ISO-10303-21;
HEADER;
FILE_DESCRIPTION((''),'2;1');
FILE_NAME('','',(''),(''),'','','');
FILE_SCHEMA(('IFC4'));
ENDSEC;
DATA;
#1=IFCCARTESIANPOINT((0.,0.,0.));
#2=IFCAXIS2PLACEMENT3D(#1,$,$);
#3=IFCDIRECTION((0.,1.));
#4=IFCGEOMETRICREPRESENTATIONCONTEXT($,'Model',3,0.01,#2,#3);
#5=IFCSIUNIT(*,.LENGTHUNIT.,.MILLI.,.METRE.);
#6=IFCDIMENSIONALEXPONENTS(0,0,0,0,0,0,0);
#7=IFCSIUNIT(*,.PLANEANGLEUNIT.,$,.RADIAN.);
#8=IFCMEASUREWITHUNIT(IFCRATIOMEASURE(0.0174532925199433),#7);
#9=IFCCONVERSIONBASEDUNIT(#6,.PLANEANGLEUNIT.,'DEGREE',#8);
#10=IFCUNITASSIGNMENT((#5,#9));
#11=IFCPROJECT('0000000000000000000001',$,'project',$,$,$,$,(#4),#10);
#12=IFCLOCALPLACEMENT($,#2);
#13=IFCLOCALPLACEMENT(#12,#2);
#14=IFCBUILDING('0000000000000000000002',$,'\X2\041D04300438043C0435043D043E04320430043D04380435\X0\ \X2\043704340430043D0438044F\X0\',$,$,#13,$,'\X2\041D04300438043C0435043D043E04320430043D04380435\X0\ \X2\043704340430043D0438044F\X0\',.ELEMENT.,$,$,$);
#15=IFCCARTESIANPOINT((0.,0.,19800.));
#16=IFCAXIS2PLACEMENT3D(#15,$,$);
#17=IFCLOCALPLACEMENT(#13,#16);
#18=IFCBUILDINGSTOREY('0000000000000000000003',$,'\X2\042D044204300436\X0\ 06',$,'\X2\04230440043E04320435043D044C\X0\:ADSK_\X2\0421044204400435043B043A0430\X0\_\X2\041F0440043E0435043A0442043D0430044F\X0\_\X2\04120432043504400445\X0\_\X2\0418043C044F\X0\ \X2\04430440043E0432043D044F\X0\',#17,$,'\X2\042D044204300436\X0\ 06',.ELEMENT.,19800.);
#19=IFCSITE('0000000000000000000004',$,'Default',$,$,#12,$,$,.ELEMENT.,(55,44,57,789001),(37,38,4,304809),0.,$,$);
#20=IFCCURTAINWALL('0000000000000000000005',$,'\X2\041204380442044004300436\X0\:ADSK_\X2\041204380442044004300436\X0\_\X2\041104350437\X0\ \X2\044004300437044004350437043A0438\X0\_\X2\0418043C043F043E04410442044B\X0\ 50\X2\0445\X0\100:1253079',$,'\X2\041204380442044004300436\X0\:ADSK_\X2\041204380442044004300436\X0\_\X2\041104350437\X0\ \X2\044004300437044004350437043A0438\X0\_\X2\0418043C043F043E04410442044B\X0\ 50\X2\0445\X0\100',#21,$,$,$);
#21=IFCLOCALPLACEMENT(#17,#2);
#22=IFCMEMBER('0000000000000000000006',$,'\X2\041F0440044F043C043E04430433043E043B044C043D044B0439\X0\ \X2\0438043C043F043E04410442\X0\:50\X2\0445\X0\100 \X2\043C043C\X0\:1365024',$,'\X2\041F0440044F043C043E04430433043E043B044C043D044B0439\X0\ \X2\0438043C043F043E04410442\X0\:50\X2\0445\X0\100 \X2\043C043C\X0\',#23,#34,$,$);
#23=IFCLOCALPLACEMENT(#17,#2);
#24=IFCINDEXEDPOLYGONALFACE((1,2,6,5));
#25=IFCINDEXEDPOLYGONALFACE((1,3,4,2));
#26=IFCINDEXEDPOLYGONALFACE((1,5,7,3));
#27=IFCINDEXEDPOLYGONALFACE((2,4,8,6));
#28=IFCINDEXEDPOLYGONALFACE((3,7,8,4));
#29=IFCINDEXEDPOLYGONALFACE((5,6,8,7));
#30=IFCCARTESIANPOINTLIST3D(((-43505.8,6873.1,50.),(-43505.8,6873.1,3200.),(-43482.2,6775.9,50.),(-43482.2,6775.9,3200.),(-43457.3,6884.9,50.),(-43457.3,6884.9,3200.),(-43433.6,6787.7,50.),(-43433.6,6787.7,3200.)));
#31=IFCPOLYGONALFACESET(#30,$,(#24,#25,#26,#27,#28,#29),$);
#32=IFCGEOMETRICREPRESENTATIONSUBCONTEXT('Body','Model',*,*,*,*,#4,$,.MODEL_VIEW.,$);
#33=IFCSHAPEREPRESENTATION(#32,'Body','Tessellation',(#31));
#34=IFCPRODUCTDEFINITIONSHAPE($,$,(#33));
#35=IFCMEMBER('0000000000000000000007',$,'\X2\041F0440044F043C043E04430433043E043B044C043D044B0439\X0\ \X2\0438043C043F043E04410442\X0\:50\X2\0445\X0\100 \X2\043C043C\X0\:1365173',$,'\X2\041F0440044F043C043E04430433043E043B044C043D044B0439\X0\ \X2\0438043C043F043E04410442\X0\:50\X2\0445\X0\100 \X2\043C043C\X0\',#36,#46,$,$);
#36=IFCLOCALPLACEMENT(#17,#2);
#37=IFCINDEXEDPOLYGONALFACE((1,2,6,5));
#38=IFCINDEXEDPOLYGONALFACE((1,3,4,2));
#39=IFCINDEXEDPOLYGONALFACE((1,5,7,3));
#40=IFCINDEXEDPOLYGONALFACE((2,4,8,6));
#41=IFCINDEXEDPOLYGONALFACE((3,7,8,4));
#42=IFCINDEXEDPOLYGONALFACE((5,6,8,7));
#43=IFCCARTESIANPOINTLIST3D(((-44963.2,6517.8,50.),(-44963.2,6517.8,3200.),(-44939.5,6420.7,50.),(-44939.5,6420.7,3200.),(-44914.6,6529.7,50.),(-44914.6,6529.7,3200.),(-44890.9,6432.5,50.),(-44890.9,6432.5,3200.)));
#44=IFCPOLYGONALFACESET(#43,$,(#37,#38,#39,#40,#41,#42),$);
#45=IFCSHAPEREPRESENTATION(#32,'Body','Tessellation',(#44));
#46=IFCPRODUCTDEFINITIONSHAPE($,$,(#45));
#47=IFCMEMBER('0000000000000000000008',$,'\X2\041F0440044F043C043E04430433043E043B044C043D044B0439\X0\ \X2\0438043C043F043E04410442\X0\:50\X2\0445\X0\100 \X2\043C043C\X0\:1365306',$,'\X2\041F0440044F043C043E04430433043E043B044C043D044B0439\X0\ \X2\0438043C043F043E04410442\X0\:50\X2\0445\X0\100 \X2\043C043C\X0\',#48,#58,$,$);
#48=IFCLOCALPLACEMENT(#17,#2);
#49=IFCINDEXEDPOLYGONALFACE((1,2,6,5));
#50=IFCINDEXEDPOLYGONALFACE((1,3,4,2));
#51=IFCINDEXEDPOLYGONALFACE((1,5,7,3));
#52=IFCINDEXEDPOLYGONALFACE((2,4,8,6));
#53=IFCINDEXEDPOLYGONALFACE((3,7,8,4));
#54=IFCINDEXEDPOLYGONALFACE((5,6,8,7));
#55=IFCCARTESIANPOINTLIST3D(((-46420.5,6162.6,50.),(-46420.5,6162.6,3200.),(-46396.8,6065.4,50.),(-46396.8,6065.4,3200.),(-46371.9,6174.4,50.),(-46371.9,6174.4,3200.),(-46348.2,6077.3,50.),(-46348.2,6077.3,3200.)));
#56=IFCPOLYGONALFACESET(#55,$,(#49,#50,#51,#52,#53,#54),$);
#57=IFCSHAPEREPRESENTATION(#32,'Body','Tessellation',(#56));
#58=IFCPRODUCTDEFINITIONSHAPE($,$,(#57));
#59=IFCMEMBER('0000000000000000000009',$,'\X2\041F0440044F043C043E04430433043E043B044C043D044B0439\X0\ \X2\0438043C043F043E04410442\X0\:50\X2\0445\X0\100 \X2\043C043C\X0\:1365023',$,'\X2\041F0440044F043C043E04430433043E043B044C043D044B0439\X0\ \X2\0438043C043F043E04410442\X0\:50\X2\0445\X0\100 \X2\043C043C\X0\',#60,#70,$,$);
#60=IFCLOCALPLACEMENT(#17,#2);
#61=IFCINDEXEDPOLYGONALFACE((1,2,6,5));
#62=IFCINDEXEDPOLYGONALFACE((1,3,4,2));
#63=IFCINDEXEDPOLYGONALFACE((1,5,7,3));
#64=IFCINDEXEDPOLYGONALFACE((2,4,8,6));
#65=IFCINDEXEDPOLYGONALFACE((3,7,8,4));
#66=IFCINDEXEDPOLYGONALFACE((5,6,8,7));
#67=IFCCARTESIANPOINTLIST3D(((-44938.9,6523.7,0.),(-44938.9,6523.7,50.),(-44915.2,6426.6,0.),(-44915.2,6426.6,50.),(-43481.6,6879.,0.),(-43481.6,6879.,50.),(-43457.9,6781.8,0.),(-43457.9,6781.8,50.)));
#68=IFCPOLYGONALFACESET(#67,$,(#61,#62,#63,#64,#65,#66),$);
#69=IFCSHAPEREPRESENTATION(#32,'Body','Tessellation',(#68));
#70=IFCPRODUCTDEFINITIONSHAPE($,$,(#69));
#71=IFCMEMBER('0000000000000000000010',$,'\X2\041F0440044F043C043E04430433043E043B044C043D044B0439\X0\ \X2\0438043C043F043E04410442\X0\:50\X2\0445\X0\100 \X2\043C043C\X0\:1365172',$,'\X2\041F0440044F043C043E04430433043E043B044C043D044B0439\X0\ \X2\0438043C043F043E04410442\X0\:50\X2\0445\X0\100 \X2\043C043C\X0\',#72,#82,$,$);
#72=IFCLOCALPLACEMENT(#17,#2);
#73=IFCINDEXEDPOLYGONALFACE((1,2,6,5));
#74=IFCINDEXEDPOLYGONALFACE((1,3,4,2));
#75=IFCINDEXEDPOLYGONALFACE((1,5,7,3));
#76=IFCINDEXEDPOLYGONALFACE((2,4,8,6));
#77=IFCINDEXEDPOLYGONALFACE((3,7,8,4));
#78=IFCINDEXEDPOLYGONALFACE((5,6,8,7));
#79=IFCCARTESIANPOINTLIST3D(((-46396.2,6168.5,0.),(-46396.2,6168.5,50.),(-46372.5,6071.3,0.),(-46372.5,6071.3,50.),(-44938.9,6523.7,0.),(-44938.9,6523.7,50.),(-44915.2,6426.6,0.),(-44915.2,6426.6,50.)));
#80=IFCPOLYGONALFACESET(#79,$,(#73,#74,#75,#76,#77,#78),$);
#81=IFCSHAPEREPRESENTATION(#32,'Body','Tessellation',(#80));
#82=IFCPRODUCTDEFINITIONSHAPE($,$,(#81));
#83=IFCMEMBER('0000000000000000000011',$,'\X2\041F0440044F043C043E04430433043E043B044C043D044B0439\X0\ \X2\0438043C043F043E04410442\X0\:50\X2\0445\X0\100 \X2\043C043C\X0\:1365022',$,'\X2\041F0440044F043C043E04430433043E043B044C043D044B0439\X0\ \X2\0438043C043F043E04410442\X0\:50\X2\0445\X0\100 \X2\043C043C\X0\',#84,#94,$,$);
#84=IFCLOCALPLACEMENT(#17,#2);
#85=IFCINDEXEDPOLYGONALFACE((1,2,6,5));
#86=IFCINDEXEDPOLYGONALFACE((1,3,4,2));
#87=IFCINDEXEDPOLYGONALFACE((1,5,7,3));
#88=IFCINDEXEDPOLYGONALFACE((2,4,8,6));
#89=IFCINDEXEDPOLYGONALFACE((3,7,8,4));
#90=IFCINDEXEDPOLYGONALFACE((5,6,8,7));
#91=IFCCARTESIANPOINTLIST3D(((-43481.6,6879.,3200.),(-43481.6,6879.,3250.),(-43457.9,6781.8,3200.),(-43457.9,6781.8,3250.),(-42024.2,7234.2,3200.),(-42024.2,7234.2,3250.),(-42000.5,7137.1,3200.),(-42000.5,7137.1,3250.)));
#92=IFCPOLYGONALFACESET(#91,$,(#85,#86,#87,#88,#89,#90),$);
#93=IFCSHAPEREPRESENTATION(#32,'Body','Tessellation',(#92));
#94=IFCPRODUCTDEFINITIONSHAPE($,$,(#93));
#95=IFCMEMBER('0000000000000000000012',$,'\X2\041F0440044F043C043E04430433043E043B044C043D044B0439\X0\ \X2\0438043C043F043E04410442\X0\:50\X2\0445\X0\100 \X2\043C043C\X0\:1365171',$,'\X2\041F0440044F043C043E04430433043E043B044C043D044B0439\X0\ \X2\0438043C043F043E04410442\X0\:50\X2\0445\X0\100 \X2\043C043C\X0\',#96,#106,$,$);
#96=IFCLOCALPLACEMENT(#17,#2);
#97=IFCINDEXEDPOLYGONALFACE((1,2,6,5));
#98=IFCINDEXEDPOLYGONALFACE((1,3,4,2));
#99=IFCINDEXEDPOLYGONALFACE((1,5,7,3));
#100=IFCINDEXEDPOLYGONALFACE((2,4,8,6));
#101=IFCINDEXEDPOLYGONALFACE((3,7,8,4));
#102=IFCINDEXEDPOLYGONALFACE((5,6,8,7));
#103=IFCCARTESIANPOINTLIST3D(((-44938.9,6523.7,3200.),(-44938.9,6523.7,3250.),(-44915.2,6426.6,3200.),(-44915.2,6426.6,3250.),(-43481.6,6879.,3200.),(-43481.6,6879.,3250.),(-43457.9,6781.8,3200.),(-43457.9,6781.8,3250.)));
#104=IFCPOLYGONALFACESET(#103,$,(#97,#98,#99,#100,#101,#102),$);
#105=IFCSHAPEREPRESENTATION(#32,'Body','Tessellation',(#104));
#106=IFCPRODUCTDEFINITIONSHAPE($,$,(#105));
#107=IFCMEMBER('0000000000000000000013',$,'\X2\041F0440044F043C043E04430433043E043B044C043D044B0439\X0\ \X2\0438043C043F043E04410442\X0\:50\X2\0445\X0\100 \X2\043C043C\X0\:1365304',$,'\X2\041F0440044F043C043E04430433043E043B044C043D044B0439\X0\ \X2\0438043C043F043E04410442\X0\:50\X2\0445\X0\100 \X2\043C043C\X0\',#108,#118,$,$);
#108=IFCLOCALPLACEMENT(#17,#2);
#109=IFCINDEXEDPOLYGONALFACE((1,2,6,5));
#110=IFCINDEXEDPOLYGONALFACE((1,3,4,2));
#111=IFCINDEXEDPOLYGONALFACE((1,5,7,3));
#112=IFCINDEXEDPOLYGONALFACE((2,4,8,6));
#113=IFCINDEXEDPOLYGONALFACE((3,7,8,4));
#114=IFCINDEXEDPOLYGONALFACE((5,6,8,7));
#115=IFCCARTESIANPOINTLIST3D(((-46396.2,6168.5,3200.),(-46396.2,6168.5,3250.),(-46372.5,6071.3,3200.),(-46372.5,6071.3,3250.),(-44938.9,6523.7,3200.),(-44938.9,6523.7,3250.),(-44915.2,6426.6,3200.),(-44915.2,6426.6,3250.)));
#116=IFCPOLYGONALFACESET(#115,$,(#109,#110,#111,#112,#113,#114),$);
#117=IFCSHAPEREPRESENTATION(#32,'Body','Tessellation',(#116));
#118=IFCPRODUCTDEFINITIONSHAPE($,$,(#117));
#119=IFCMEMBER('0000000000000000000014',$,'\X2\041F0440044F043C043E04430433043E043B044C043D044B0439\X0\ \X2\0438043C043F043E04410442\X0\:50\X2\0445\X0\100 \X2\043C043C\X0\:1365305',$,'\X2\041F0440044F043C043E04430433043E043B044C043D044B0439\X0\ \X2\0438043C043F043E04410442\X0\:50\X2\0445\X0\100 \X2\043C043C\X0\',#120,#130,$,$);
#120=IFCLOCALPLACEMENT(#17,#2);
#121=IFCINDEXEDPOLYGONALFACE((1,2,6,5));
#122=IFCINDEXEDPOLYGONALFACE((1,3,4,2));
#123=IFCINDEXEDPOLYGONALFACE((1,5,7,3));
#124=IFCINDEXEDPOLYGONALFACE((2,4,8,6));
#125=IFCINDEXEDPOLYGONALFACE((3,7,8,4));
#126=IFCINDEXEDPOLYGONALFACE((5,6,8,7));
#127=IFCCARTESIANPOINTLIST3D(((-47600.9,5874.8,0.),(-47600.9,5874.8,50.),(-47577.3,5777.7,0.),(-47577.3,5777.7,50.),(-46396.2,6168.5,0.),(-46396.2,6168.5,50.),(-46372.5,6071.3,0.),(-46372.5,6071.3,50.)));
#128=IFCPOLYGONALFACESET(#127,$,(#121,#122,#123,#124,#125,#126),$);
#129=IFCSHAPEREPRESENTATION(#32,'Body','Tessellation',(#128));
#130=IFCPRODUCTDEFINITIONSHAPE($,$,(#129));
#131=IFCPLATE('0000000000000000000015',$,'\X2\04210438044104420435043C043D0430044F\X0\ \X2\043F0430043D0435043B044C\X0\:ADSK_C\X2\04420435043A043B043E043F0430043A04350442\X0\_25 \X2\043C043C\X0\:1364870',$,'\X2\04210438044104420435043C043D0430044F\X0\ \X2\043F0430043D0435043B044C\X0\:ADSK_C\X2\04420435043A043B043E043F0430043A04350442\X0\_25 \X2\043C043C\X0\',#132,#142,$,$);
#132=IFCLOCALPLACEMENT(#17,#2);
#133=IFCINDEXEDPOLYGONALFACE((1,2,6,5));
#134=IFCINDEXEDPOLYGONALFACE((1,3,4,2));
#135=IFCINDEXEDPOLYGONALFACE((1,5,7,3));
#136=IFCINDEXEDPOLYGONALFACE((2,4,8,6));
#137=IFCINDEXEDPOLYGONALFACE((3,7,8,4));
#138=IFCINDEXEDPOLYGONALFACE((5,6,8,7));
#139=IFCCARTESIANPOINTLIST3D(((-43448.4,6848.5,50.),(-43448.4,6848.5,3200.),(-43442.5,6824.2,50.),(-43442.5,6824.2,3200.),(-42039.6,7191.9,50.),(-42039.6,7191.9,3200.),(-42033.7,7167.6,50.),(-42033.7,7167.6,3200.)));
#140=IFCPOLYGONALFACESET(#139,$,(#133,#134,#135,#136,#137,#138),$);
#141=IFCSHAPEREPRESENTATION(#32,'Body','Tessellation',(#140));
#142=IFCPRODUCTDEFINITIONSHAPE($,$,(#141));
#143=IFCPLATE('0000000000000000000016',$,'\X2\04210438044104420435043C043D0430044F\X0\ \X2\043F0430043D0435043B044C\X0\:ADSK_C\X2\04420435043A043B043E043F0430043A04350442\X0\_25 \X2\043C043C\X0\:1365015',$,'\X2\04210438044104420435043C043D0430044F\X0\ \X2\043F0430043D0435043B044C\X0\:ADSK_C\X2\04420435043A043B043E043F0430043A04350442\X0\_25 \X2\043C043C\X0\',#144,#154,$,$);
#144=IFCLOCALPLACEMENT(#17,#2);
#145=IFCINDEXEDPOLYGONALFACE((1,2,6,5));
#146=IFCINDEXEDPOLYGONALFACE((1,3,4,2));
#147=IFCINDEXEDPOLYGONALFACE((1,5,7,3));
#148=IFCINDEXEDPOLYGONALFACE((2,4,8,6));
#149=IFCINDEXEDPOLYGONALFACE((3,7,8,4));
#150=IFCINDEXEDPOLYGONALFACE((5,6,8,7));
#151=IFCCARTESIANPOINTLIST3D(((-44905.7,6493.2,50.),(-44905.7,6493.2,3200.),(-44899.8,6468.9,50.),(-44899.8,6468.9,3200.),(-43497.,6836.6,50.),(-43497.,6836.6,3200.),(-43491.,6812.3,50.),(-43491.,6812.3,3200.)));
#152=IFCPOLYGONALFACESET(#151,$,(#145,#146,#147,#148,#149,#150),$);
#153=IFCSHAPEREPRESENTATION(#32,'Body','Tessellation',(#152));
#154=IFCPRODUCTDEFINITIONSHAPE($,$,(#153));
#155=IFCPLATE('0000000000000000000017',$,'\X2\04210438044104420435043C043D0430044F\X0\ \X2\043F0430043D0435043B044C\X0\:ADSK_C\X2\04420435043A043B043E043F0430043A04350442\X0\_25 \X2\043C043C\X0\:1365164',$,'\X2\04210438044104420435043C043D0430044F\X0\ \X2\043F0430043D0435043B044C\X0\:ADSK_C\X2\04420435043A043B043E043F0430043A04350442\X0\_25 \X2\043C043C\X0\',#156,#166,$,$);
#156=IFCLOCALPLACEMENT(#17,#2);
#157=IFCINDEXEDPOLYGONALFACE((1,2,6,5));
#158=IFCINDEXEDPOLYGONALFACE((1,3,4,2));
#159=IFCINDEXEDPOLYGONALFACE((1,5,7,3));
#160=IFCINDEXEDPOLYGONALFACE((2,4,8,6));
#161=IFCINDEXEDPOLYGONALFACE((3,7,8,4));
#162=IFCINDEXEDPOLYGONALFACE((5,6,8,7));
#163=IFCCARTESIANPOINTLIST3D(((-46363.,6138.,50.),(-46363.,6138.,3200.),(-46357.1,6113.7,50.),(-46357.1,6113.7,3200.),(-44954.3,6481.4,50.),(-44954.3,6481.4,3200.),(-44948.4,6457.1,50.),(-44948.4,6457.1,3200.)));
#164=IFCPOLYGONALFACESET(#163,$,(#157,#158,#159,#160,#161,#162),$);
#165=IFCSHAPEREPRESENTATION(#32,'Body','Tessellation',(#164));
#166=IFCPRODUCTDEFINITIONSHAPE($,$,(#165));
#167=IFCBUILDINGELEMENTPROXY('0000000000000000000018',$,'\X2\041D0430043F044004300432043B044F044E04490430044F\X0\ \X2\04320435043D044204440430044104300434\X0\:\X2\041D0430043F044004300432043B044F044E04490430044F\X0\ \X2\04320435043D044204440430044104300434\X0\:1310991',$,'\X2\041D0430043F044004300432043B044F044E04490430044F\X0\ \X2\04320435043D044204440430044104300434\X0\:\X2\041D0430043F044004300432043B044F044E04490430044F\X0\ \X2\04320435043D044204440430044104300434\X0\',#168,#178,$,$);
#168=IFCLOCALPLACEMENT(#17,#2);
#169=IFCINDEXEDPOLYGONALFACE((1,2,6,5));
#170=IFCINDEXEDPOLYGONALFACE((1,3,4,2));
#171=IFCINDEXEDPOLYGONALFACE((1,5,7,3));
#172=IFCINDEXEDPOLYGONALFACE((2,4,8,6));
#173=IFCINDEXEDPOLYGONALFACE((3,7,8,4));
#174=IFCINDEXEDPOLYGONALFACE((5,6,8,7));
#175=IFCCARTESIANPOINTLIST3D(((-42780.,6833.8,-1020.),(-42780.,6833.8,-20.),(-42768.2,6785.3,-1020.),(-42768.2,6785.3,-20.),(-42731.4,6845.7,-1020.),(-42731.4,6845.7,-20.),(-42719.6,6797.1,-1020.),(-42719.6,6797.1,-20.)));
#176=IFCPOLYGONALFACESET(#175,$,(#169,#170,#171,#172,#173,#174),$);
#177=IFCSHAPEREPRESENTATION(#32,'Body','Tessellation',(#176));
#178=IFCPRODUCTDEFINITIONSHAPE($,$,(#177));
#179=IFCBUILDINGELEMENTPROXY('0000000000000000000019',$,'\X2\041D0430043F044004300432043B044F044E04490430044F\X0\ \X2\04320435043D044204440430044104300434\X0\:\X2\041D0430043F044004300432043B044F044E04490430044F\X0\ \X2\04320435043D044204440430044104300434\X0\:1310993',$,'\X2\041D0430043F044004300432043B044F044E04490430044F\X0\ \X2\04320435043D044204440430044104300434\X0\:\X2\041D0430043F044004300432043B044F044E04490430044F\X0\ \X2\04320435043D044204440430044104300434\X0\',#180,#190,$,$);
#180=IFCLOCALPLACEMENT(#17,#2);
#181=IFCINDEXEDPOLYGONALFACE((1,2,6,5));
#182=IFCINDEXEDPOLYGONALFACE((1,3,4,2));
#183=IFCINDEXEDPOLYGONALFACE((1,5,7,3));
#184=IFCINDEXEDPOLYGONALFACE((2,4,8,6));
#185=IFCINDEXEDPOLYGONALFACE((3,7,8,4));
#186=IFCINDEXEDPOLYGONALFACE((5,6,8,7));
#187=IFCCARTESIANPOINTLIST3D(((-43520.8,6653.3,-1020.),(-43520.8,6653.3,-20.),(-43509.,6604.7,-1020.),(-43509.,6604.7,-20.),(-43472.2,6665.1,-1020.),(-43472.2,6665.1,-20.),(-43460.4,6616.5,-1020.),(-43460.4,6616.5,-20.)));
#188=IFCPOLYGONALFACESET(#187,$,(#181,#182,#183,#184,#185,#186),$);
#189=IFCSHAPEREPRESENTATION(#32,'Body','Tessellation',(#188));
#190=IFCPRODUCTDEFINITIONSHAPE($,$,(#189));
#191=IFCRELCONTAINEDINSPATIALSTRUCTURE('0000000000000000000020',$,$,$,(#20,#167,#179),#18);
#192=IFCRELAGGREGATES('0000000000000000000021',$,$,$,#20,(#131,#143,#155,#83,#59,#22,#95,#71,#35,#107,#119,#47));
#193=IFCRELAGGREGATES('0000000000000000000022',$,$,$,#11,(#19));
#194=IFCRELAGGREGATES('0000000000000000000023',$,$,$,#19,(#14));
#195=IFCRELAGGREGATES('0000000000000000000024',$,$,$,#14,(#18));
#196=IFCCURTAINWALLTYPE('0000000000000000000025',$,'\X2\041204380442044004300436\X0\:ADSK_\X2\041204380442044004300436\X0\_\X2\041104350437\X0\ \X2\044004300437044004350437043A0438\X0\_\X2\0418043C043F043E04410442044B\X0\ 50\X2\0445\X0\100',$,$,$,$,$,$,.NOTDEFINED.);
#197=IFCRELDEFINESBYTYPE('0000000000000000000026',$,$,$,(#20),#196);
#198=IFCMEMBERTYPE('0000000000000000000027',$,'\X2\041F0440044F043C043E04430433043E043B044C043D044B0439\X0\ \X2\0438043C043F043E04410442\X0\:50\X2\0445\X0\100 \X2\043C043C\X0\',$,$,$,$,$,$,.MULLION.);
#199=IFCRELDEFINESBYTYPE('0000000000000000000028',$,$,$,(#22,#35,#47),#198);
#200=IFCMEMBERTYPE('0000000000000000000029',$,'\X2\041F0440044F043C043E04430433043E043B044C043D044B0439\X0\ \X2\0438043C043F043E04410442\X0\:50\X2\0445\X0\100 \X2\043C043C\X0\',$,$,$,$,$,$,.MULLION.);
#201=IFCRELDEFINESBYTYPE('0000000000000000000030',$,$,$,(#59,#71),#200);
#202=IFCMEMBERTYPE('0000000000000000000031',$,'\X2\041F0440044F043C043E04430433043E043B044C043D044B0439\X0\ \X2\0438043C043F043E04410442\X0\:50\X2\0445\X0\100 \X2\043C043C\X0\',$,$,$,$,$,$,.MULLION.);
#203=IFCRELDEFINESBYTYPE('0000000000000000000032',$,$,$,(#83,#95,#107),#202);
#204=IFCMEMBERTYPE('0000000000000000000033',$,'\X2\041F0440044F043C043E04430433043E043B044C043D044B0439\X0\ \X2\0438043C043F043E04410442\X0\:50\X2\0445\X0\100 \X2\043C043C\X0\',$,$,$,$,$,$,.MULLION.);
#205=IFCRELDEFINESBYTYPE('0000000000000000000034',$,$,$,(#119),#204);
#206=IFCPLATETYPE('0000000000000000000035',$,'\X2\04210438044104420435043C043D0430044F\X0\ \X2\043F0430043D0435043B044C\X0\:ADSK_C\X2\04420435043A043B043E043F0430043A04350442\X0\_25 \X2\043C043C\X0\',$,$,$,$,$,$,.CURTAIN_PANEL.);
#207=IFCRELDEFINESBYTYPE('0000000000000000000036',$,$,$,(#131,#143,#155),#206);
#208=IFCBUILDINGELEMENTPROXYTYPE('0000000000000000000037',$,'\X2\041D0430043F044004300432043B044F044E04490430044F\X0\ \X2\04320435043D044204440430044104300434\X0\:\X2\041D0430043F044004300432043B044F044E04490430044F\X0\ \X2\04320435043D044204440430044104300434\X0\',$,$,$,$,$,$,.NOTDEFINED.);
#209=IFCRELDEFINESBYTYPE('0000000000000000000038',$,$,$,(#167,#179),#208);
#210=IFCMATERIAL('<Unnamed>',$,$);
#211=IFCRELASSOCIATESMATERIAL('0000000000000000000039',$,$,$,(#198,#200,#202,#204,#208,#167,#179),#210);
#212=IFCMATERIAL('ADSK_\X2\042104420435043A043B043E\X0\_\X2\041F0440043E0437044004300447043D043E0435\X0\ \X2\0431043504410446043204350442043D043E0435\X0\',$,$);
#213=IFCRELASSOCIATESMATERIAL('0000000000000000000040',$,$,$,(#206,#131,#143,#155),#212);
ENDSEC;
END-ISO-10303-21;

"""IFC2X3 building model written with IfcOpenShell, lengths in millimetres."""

from ifc_helpers import new_model, entity, si_unit, converted_unit, direction, frame, frame_2d, origin, origin_2d_with_axis, place, context, subcontext, project, spatial, rectangle, extrude, source, transform, mapped, material, type_object, type_shapes, element, aggregate, save


model = new_model("IFC2X3")

# Units and contexts
model_context = context("Model", 3, precision=0.01, world=origin(), true_north=direction((0.0, 1.0)))
body_context = subcontext(model_context, "Body", "Model", "MODEL_VIEW")
ifc_project = project(units=[si_unit("LENGTHUNIT", "METRE", prefix="MILLI"), converted_unit("PLANEANGLEUNIT", "DEGREE", entity("IfcRatioMeasure", 0.0174532925199433), si_unit("PLANEANGLEUNIT", "RADIAN"), dimensions=[0, 0, 0, 0, 0, 0, 0])], contexts=[model_context])

# Site, building, storey
site_placement = place(None, origin())
site = spatial("IfcSite", under=ifc_project, at=site_placement, Name="Default", CompositionType="ELEMENT", RefLatitude=(55, 44, 57, 789001), RefLongitude=(37, 38, 4, 304809), RefElevation=0.0)
building_placement = place(site_placement, origin())
building = spatial("IfcBuilding", under=site, at=building_placement, Name="Наименование здания", LongName="Наименование здания", CompositionType="ELEMENT")
storey_placement = place(building_placement, frame((0.0, 0.0, 19800.0)))
storey = spatial("IfcBuildingStorey", under=building, at=storey_placement, Name="Этаж 06", ObjectType="Уровень:ADSK_Стрелка_Проектная_Вверх_Имя уровня", LongName="Этаж 06", CompositionType="ELEMENT", Elevation=19800.0)

# Curtain wall, members, plates
curtain_wall_type = type_object("IfcCurtainWallType", Name="Витраж:ADSK_Витраж_Без разрезки_Импосты 50х100", PredefinedType="NOTDEFINED")
curtain_wall_placement = place(storey_placement, frame((0.0, 0.0, -19800.0)))
curtain_wall = element("IfcCurtainWall", 1, at=curtain_wall_placement, inside=storey, type_object=curtain_wall_type, Name="Витраж:ADSK_Витраж_Без разрезки_Импосты 50х100:1253079", ObjectType="Витраж:ADSK_Витраж_Без разрезки_Импосты 50х100")
ifc_material_1 = material(Name="<Unnamed>")
member_type_1 = type_object("IfcMemberType", Name="Прямоугольный импост:50х100 мм", PredefinedType="MULLION", material=ifc_material_1)
shared_shape_1 = source(origin(), body_context, "Body", "SweptSolid", [
    extrude(rectangle(XDim=100.0, YDim=50.0, at=origin_2d_with_axis()), frame((0.0, 0.0, -3150.0), z_axis=(0.0, 0.0, 1.0), x_axis=(0.0, -1.0, 0.0)), (0.0, 0.0, 1.0), 3150.0),
])
type_shapes(member_type_1, [shared_shape_1])
member_1_placement = place(storey_placement, frame((-43469.7, 6830.4, 50.0), z_axis=(0.0, 0.0, -1.0), x_axis=(-0.971552, -0.236826, 0.0)))
member_1 = element("IfcMember", 2, at=member_1_placement, type_object=member_type_1, Name="Прямоугольный импост:50х100 мм:1365024", ObjectType="Прямоугольный импост:50х100 мм", context=body_context, shape_type="MappedRepresentation", body=[
    mapped(shared_shape_1, transform((0.0, 0.0, 0.0), scale=1.0)),
])
member_2_placement = place(storey_placement, frame((-44927.0, 6475.2, 50.0), z_axis=(0.0, 0.0, -1.0), x_axis=(-0.971552, -0.236826, 0.0)))
member_2 = element("IfcMember", 3, at=member_2_placement, type_object=member_type_1, Name="Прямоугольный импост:50х100 мм:1365173", ObjectType="Прямоугольный импост:50х100 мм", context=body_context, shape_type="MappedRepresentation", body=[
    mapped(shared_shape_1, transform((0.0, 0.0, 0.0), scale=1.0)),
])
member_3_placement = place(storey_placement, frame((-46384.4, 6119.9, 50.0), z_axis=(0.0, 0.0, -1.0), x_axis=(-0.971552, -0.236826, 0.0)))
member_3 = element("IfcMember", 4, at=member_3_placement, type_object=member_type_1, Name="Прямоугольный импост:50х100 мм:1365306", ObjectType="Прямоугольный импост:50х100 мм", context=body_context, shape_type="MappedRepresentation", body=[
    mapped(shared_shape_1, transform((0.0, 0.0, 0.0), scale=1.0)),
])
member_type_2 = type_object("IfcMemberType", Name="Прямоугольный импост:50х100 мм", PredefinedType="MULLION", material=ifc_material_1)
shared_shape_2 = source(origin(), body_context, "Body", "SweptSolid", [
    extrude(rectangle(XDim=100.0, YDim=50.0, at=origin_2d_with_axis()), frame((-25.0, 0.0, -1500.0), z_axis=(0.0, 0.0, 1.0), x_axis=(0.0, -1.0, 0.0)), (0.0, 0.0, 1.0), 1500.0),
])
type_shapes(member_type_2, [shared_shape_2])
member_4_placement = place(storey_placement, frame((-43469.7, 6830.4, 0.0), z_axis=(0.971552, 0.236826, 0.0), x_axis=(0.0, 0.0, -1.0)))
member_4 = element("IfcMember", 5, at=member_4_placement, type_object=member_type_2, Name="Прямоугольный импост:50х100 мм:1365023", ObjectType="Прямоугольный импост:50х100 мм", context=body_context, shape_type="MappedRepresentation", body=[
    mapped(shared_shape_2, transform((0.0, 0.0, 0.0), scale=1.0)),
])
member_5_placement = place(storey_placement, frame((-44927.0, 6475.2, 0.0), z_axis=(0.971552, 0.236826, 0.0), x_axis=(0.0, 0.0, -1.0)))
member_5 = element("IfcMember", 6, at=member_5_placement, type_object=member_type_2, Name="Прямоугольный импост:50х100 мм:1365172", ObjectType="Прямоугольный импост:50х100 мм", context=body_context, shape_type="MappedRepresentation", body=[
    mapped(shared_shape_2, transform((0.0, 0.0, 0.0), scale=1.0)),
])
member_type_3 = type_object("IfcMemberType", Name="Прямоугольный импост:50х100 мм", PredefinedType="MULLION", material=ifc_material_1)
shared_shape_3 = source(origin(), body_context, "Body", "SweptSolid", [
    extrude(rectangle(XDim=100.0, YDim=50.0, at=origin_2d_with_axis()), frame((-25.0, 0.0, -1500.0), z_axis=(0.0, 0.0, 1.0), x_axis=(0.0, -1.0, 0.0)), (0.0, 0.0, 1.0), 1500.0),
])
type_shapes(member_type_3, [shared_shape_3])
member_6_placement = place(storey_placement, frame((-43469.7, 6830.4, 3250.0), z_axis=(-0.971552, -0.236826, 0.0), x_axis=(0.0, 0.0, 1.0)))
member_6 = element("IfcMember", 7, at=member_6_placement, type_object=member_type_3, Name="Прямоугольный импост:50х100 мм:1365022", ObjectType="Прямоугольный импост:50х100 мм", context=body_context, shape_type="MappedRepresentation", body=[
    mapped(shared_shape_3, transform((0.0, 0.0, 0.0), scale=1.0)),
])
member_7_placement = place(storey_placement, frame((-44927.0, 6475.2, 3250.0), z_axis=(-0.971552, -0.236826, 0.0), x_axis=(0.0, 0.0, 1.0)))
member_7 = element("IfcMember", 8, at=member_7_placement, type_object=member_type_3, Name="Прямоугольный импост:50х100 мм:1365171", ObjectType="Прямоугольный импост:50х100 мм", context=body_context, shape_type="MappedRepresentation", body=[
    mapped(shared_shape_3, transform((0.0, 0.0, 0.0), scale=1.0)),
])
member_8_placement = place(storey_placement, frame((-46384.4, 6119.9, 3250.0), z_axis=(-0.971552, -0.236826, 0.0), x_axis=(0.0, 0.0, 1.0)))
member_8 = element("IfcMember", 9, at=member_8_placement, type_object=member_type_3, Name="Прямоугольный импост:50х100 мм:1365304", ObjectType="Прямоугольный импост:50х100 мм", context=body_context, shape_type="MappedRepresentation", body=[
    mapped(shared_shape_3, transform((0.0, 0.0, 0.0), scale=1.0)),
])
member_type_4 = type_object("IfcMemberType", Name="Прямоугольный импост:50х100 мм", PredefinedType="MULLION", material=ifc_material_1)
shared_shape_4 = source(origin(), body_context, "Body", "SweptSolid", [
    extrude(rectangle(XDim=100.0, YDim=50.0, at=origin_2d_with_axis()), frame((-25.0, 0.0, -1240.0), z_axis=(0.0, 0.0, 1.0), x_axis=(0.0, -1.0, 0.0)), (0.0, 0.0, 1.0), 1240.0),
])
type_shapes(member_type_4, [shared_shape_4])
member_9_placement = place(storey_placement, frame((-46384.4, 6119.9, 0.0), z_axis=(0.971552, 0.236826, 0.0), x_axis=(0.0, 0.0, -1.0)))
member_9 = element("IfcMember", 10, at=member_9_placement, type_object=member_type_4, Name="Прямоугольный импост:50х100 мм:1365305", ObjectType="Прямоугольный импост:50х100 мм", context=body_context, shape_type="MappedRepresentation", body=[
    mapped(shared_shape_4, transform((0.0, 0.0, 0.0), scale=1.0)),
])
ifc_material_2 = material(Name="ADSK_Стекло_Прозрачное бесцветное")
plate_type = type_object("IfcPlateType", Name="Системная панель:ADSK_Cтеклопакет_25 мм", PredefinedType="CURTAIN_PANEL", material=ifc_material_2)
shared_shape_5 = source(origin(), body_context, "Body", "SweptSolid", [
    extrude(rectangle(XDim=25.0, YDim=1450.0, at=frame_2d((0.0, 0.0), x_axis=(1.0, 0.0))), frame((0.0, 0.0, 0.0), z_axis=(0.0, 0.0, 1.0), x_axis=(0.0, 1.0, 0.0)), (0.0, 0.0, 1.0), 3150.0),
])
type_shapes(plate_type, [shared_shape_5])
plate_1_placement = place(curtain_wall_placement, frame((-42741.1, 7008.0, 19850.0), z_axis=(0.0, 0.0, 1.0), x_axis=(-0.971552, -0.236826, 0.0)))
plate_1 = element("IfcPlate", 11, at=plate_1_placement, type_object=plate_type, material=ifc_material_2, Name="Системная панель:ADSK_Cтеклопакет_25 мм:1364870", ObjectType="Системная панель:ADSK_Cтеклопакет_25 мм", context=body_context, shape_type="MappedRepresentation", body=[
    mapped(shared_shape_5, transform((0.0, 0.0, 0.0), scale=1.0)),
])
plate_2_placement = place(curtain_wall_placement, frame((-44198.4, 6652.8, 19850.0), z_axis=(0.0, 0.0, 1.0), x_axis=(-0.971552, -0.236826, 0.0)))
plate_2 = element("IfcPlate", 12, at=plate_2_placement, type_object=plate_type, material=ifc_material_2, Name="Системная панель:ADSK_Cтеклопакет_25 мм:1365015", ObjectType="Системная панель:ADSK_Cтеклопакет_25 мм", context=body_context, shape_type="MappedRepresentation", body=[
    mapped(shared_shape_5, transform((0.0, 0.0, 0.0), scale=1.0)),
])
plate_3_placement = place(curtain_wall_placement, frame((-45655.7, 6297.5, 19850.0), z_axis=(0.0, 0.0, 1.0), x_axis=(-0.971552, -0.236826, 0.0)))
plate_3 = element("IfcPlate", 13, at=plate_3_placement, type_object=plate_type, material=ifc_material_2, Name="Системная панель:ADSK_Cтеклопакет_25 мм:1365164", ObjectType="Системная панель:ADSK_Cтеклопакет_25 мм", context=body_context, shape_type="MappedRepresentation", body=[
    mapped(shared_shape_5, transform((0.0, 0.0, 0.0), scale=1.0)),
])
aggregate(curtain_wall, [plate_1, plate_2, plate_3, member_6, member_4, member_1, member_7, member_5, member_2, member_8, member_9, member_3])

# Building element proxies
building_element_proxy_type_1 = type_object("IfcBuildingElementProxyType", Name="Направляющая вентфасад:Направляющая вентфасад", PredefinedType="NOTDEFINED", material=ifc_material_1)
shared_shape_6 = source(origin(), body_context, "Body", "SweptSolid", [
    extrude(rectangle(XDim=50.0, YDim=50.0, at=origin_2d_with_axis()), frame((25.0, -25.0, 0.0), z_axis=(0.0, 0.0, 1.0), x_axis=(-1.0, 0.0, 0.0)), (0.0, 0.0, 1.0), 1000.0),
])
type_shapes(building_element_proxy_type_1, [shared_shape_6])
for number, where, z_axis, x_axis, name in (
    (14, (-42780.0, 6833.8, -1020.0), (0.0, 0.0, 1.0), (0.971552, 0.236826, 0.0), "Направляющая вентфасад:Направляющая вентфасад:1310991"),
    (15, (-43520.8, 6653.3, -1020.0), (0.0, 0.0, 1.0), (0.971552, 0.236826, 0.0), "Направляющая вентфасад:Направляющая вентфасад:1310993"),
):
    element("IfcBuildingElementProxy", number, at=place(storey_placement, frame(where, z_axis=z_axis, x_axis=x_axis)), inside=storey, type_object=building_element_proxy_type_1, material=ifc_material_1, Name=name, ObjectType="Направляющая вентфасад:Направляющая вентфасад", context=body_context, shape_type="MappedRepresentation", body=[
        mapped(shared_shape_6, transform((0.0, 0.0, 0.0), scale=1.0)),
    ])

save(model, "model.ifc")
